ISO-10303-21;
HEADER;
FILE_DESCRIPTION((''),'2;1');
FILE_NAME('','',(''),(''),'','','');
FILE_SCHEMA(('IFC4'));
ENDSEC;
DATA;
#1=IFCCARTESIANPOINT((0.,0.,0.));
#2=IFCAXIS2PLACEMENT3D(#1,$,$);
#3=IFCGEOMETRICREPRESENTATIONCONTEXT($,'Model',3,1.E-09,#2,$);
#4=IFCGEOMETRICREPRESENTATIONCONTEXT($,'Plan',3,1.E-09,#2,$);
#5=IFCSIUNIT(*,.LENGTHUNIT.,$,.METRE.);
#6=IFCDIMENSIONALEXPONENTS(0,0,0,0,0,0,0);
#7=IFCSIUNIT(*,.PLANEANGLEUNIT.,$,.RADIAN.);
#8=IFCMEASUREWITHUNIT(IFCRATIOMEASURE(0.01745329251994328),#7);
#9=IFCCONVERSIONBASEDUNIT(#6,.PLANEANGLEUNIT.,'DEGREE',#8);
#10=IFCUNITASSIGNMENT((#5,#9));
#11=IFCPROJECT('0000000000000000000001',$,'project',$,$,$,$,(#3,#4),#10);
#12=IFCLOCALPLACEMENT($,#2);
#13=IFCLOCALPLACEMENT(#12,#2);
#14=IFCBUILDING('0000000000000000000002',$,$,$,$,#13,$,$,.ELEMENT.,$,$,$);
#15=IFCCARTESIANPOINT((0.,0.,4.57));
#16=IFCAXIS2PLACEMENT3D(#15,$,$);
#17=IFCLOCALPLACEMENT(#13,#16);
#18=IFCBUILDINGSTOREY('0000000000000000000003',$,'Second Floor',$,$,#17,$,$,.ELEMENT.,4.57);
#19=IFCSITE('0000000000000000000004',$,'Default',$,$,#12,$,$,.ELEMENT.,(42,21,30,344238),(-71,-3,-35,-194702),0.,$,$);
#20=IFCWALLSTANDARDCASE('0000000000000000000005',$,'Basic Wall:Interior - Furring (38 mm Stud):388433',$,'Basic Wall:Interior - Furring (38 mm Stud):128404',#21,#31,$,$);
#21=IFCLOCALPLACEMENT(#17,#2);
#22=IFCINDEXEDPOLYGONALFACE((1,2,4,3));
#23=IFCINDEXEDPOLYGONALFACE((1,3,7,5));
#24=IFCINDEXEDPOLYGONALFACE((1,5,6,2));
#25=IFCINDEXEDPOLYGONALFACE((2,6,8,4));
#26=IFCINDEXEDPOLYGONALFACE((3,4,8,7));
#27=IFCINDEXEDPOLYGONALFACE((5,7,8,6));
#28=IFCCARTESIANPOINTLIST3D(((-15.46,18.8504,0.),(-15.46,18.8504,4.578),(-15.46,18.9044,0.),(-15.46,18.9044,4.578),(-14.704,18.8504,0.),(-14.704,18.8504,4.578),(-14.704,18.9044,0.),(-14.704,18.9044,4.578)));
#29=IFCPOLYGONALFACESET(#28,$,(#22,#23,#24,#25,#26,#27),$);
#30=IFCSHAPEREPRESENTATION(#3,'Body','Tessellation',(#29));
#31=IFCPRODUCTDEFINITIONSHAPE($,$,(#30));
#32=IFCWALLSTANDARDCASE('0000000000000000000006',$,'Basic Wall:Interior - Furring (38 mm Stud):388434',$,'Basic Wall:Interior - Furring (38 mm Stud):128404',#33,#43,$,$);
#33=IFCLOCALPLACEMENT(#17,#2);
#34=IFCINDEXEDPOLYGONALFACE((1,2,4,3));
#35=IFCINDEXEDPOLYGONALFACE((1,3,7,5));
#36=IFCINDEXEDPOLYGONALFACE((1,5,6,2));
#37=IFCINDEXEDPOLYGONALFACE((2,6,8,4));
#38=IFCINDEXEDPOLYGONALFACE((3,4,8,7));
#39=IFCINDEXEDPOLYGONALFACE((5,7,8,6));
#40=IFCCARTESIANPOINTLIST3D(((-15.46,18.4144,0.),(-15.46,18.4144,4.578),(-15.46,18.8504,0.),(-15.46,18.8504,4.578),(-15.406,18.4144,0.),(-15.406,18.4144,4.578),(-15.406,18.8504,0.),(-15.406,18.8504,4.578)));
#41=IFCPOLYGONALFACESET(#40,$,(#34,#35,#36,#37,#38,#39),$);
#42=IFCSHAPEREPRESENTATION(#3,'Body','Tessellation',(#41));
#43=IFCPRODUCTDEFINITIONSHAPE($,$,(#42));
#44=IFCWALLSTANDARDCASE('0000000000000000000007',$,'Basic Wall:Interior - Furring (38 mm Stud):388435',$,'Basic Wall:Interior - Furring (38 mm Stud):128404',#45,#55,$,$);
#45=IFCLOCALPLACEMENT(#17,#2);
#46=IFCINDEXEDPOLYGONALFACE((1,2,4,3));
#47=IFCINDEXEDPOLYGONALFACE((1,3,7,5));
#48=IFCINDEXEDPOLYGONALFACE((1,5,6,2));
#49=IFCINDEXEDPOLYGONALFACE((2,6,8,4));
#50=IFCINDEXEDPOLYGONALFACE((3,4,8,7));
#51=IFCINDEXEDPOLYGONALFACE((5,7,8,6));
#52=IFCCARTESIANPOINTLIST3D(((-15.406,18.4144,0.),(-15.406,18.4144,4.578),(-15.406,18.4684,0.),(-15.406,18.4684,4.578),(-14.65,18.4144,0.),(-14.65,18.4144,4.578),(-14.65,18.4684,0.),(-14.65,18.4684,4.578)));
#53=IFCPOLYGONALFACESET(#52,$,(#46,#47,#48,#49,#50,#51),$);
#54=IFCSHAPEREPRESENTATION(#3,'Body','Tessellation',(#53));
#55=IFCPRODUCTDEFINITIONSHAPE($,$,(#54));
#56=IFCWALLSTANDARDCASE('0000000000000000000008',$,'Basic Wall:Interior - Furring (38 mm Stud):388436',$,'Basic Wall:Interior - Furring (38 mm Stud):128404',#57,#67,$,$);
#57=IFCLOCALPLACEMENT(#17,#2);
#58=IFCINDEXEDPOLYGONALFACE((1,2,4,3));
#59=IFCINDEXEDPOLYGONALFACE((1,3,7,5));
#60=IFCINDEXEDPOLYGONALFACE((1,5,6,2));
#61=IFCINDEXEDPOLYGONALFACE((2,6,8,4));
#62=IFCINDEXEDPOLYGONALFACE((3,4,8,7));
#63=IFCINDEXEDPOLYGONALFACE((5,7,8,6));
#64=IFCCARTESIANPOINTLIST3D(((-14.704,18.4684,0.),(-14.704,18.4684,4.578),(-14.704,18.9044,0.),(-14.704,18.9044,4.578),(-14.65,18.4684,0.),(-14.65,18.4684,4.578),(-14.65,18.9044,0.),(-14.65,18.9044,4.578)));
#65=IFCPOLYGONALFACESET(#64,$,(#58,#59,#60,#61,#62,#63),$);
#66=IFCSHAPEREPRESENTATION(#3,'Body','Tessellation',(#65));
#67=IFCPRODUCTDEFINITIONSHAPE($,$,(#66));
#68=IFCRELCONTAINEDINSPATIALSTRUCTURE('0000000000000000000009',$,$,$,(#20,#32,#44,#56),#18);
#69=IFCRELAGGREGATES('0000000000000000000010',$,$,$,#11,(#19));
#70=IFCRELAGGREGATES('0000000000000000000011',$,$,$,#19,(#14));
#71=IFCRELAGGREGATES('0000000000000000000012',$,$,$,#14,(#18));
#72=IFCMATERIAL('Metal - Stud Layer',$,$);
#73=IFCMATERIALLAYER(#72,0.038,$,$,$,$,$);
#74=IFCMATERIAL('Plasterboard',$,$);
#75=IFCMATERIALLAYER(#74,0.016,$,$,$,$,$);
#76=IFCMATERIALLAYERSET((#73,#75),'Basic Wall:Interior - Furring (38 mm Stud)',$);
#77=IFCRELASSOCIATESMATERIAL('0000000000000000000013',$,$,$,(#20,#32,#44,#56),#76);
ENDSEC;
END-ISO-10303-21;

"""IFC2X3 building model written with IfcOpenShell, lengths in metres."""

from ifc_helpers import new_model, entity, si_unit, converted_unit, frame, frame_2d, origin, place, context, project, spatial, rectangle, extrude, material, layer, layer_set, layer_usage, element, save


model = new_model("IFC2X3")

# Units and contexts
model_context = context("Model", 3, precision=1e-09, world=origin())
plan_context = context("Plan", 3, precision=1e-09, world=origin())
ifc_project = project(units=[si_unit("LENGTHUNIT", "METRE"), converted_unit("PLANEANGLEUNIT", "DEGREE", entity("IfcRatioMeasure", 0.01745329251994328), si_unit("PLANEANGLEUNIT", "RADIAN"), dimensions=[0, 0, 0, 0, 0, 0, 0])], contexts=[model_context, plan_context])

# Site, building, storey
site_placement = place(None, origin())
site = spatial("IfcSite", under=ifc_project, at=site_placement, Name="Default", CompositionType="ELEMENT", RefLatitude=(42, 21, 30, 344238), RefLongitude=(-71, -3, -35, -194702), RefElevation=0.0)
building_placement = place(site_placement, origin())
building = spatial("IfcBuilding", under=site, at=building_placement, CompositionType="ELEMENT")
storey_placement = place(building_placement, frame((0.0, 0.0, 4.57)))
storey = spatial("IfcBuildingStorey", under=building, at=storey_placement, Name="Second Floor", CompositionType="ELEMENT", Elevation=4.57)

# Shared definitions
ifc_material_1 = material(Name="Plasterboard")
ifc_material_2 = material(Name="Metal - Stud Layer")

# Shared definitions
ifc_layer_1 = layer(ifc_material_2, 0.038)
ifc_layer_2 = layer(ifc_material_1, 0.016)
ifc_layer_set_1 = layer_set([ifc_layer_1, ifc_layer_2], Name="Basic Wall:Interior - Furring (38 mm Stud)")

# Walls
ifc_layer_usage_1 = layer_usage(ifc_layer_set_1, "AXIS2", "POSITIVE", -0.027)
wall_1_placement = place(storey_placement, frame((-15.46, 18.8774, 0.0)))
element("IfcWallStandardCase", 1, at=wall_1_placement, inside=storey, material=ifc_layer_usage_1, Name="Basic Wall:Interior - Furring (38 mm Stud):388433", ObjectType="Basic Wall:Interior - Furring (38 mm Stud):128404", context=model_context, shape_type="SweptSolid", body=[
    extrude(rectangle(XDim=0.756, YDim=0.054, at=frame_2d((0.378, 0.0), x_axis=(-1.0, 0.0))), origin(), (0.0, 0.0, 1.0), 4.578),
])
ifc_layer_usage_2 = layer_usage(ifc_layer_set_1, "AXIS2", "POSITIVE", -0.027)
wall_2_placement = place(storey_placement, frame((-15.433, 18.4144, 0.0), z_axis=(0.0, 0.0, 1.0), x_axis=(0.0, 1.0, 0.0)))
element("IfcWallStandardCase", 2, at=wall_2_placement, inside=storey, material=ifc_layer_usage_2, Name="Basic Wall:Interior - Furring (38 mm Stud):388434", ObjectType="Basic Wall:Interior - Furring (38 mm Stud):128404", context=model_context, shape_type="SweptSolid", body=[
    extrude(rectangle(XDim=0.436, YDim=0.054, at=frame_2d((0.218, 0.0), x_axis=(-1.0, 0.0))), origin(), (0.0, 0.0, 1.0), 4.578),
])
ifc_layer_usage_3 = layer_usage(ifc_layer_set_1, "AXIS2", "POSITIVE", -0.027)
wall_3_placement = place(storey_placement, frame((-14.65, 18.4414, 0.0), z_axis=(0.0, 0.0, 1.0), x_axis=(-1.0, 0.0, 0.0)))
element("IfcWallStandardCase", 3, at=wall_3_placement, inside=storey, material=ifc_layer_usage_3, Name="Basic Wall:Interior - Furring (38 mm Stud):388435", ObjectType="Basic Wall:Interior - Furring (38 mm Stud):128404", context=model_context, shape_type="SweptSolid", body=[
    extrude(rectangle(XDim=0.756, YDim=0.054, at=frame_2d((0.378, 0.0), x_axis=(-1.0, 0.0))), origin(), (0.0, 0.0, 1.0), 4.578),
])
ifc_layer_usage_4 = layer_usage(ifc_layer_set_1, "AXIS2", "POSITIVE", -0.027)
wall_4_placement = place(storey_placement, frame((-14.677, 18.9044, 0.0), z_axis=(0.0, 0.0, 1.0), x_axis=(0.0, -1.0, 0.0)))
element("IfcWallStandardCase", 4, at=wall_4_placement, inside=storey, material=ifc_layer_usage_4, Name="Basic Wall:Interior - Furring (38 mm Stud):388436", ObjectType="Basic Wall:Interior - Furring (38 mm Stud):128404", context=model_context, shape_type="SweptSolid", body=[
    extrude(rectangle(XDim=0.436, YDim=0.054, at=frame_2d((0.218, 0.0), x_axis=(-1.0, 0.0))), origin(), (0.0, 0.0, 1.0), 4.578),
])

save(model, "model.ifc")
